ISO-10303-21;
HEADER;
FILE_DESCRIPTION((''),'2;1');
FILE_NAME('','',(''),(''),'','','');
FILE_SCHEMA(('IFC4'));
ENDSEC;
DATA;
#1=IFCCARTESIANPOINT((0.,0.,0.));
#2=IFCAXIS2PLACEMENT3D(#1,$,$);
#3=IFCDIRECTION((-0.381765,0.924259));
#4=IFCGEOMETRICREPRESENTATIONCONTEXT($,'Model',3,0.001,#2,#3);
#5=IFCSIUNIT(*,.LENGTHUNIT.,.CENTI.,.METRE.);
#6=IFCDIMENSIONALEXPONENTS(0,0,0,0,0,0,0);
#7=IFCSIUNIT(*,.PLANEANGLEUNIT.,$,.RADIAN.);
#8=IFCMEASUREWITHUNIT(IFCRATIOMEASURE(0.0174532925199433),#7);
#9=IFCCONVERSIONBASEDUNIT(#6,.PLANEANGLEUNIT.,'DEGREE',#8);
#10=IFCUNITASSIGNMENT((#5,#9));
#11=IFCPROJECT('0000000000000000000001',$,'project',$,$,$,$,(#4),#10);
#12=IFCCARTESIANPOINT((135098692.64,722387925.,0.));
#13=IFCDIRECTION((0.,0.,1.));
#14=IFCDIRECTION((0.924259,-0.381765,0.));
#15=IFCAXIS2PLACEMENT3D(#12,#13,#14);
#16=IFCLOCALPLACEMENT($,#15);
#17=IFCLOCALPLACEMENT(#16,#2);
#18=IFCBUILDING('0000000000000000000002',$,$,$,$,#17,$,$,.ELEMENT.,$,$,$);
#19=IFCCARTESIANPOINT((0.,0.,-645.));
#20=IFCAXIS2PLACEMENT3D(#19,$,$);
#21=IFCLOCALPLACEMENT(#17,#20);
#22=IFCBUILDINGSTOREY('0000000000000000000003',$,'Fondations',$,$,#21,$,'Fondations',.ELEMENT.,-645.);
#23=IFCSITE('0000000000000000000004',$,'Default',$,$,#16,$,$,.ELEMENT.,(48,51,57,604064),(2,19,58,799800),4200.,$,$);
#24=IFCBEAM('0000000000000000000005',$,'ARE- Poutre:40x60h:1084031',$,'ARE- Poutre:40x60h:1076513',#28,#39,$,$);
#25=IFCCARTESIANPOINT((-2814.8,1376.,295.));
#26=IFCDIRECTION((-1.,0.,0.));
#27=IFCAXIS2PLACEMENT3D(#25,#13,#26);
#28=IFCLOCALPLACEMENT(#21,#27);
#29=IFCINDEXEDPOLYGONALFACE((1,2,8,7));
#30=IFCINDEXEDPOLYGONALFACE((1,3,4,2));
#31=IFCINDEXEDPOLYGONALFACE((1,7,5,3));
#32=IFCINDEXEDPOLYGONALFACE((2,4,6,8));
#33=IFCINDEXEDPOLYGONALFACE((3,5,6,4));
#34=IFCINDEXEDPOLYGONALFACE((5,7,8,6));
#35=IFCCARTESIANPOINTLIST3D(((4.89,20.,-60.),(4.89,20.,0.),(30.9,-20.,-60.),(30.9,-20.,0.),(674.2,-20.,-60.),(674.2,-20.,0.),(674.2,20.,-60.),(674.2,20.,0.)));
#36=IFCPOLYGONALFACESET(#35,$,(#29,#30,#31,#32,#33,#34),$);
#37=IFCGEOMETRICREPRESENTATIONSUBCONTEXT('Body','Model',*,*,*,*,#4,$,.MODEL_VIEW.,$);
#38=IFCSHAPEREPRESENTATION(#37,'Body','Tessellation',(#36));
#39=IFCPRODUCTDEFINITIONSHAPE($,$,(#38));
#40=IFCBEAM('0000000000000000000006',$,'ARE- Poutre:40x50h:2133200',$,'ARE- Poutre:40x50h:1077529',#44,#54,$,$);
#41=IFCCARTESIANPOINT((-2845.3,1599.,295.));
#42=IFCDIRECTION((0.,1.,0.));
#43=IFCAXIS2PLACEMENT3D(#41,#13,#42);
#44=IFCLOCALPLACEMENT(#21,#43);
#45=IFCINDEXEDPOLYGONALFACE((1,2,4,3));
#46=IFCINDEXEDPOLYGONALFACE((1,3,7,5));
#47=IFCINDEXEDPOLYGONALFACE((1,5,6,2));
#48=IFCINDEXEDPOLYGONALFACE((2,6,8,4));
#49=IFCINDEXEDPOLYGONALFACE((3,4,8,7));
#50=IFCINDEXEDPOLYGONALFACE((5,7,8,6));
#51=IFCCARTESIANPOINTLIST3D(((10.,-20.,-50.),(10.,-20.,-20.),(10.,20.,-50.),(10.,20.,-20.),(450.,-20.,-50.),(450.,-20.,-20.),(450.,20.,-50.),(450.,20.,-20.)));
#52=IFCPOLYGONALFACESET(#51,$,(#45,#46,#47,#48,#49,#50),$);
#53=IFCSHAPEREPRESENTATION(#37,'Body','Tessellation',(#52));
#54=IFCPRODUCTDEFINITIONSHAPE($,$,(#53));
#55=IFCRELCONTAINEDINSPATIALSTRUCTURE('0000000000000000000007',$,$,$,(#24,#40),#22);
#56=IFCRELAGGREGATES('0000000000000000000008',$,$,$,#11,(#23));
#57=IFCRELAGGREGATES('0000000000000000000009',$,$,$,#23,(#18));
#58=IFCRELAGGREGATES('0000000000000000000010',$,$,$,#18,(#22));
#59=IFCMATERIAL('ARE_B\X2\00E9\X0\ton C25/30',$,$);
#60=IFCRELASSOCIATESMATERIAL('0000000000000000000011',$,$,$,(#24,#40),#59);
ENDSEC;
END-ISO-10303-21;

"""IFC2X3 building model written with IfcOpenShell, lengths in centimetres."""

from ifc_helpers import new_model, entity, si_unit, converted_unit, direction, frame, frame_2d, origin, place, context, subcontext, project, spatial, rectangle, extrude, clip, halfspace, material, element, save


model = new_model("IFC2X3")

# Units and contexts
model_context = context("Model", 3, precision=0.001, world=origin(), true_north=direction((-0.381765, 0.924259)))
body_context = subcontext(model_context, "Body", "Model", "MODEL_VIEW")
ifc_project = project(units=[si_unit("LENGTHUNIT", "METRE", prefix="CENTI"), converted_unit("PLANEANGLEUNIT", "DEGREE", entity("IfcRatioMeasure", 0.0174532925199433), si_unit("PLANEANGLEUNIT", "RADIAN"), dimensions=[0, 0, 0, 0, 0, 0, 0])], contexts=[model_context])

# Site, building, storey
site_placement = place(None, frame((135098692.64, 722387925.0, 0.0), z_axis=(0.0, 0.0, 1.0), x_axis=(0.924259, -0.381765, 0.0)))
site = spatial("IfcSite", under=ifc_project, at=site_placement, Name="Default", CompositionType="ELEMENT", RefLatitude=(48, 51, 57, 604064), RefLongitude=(2, 19, 58, 799800), RefElevation=4200.0)
building_placement = place(site_placement, origin())
building = spatial("IfcBuilding", under=site, at=building_placement, CompositionType="ELEMENT")
storey_placement = place(building_placement, frame((0.0, 0.0, -645.0)))
storey = spatial("IfcBuildingStorey", under=building, at=storey_placement, Name="Fondations", LongName="Fondations", CompositionType="ELEMENT", Elevation=-645.0)

# Beams
ifc_material_1 = material(Name="ARE_Béton C25/30")
beam_1_placement = place(storey_placement, frame((-2814.8, 1376.0, 295.0), z_axis=(0.0, 0.0, 1.0), x_axis=(-1.0, 0.0, 0.0)))
element("IfcBeam", 1, at=beam_1_placement, inside=storey, material=ifc_material_1, Name="ARE- Poutre:40x60h:1084031", ObjectType="ARE- Poutre:40x60h:1076513", context=body_context, shape_type="Clipping", body=[
    clip(extrude(rectangle(XDim=60.0, YDim=40.0, at=frame_2d((0.0, 0.0), x_axis=(1.0, 0.0))), frame((4.89, 0.0, -30.0), z_axis=(1.0, 0.0, 0.0), x_axis=(0.0, 0.0, -1.0)), (0.0, 0.0, 1.0), 669.31), halfspace(frame((50.11, -49.53, -260.0), z_axis=(-0.838282, -0.545236, 0.0), x_axis=(-0.545236, 0.838282, 0.0)), False)),
])
beam_2_placement = place(storey_placement, frame((-2845.3, 1599.0, 295.0), z_axis=(0.0, 0.0, 1.0), x_axis=(0.0, 1.0, 0.0)))
element("IfcBeam", 2, at=beam_2_placement, inside=storey, material=ifc_material_1, Name="ARE- Poutre:40x50h:2133200", ObjectType="ARE- Poutre:40x50h:1077529", context=body_context, shape_type="SweptSolid", body=[
    extrude(rectangle(XDim=30.0, YDim=40.0, at=frame_2d((0.0, 0.0), x_axis=(1.0, 0.0))), frame((10.0, 0.0, -35.0), z_axis=(1.0, 0.0, 0.0), x_axis=(0.0, 0.0, -1.0)), (0.0, 0.0, 1.0), 440.0),
])

save(model, "model.ifc")
